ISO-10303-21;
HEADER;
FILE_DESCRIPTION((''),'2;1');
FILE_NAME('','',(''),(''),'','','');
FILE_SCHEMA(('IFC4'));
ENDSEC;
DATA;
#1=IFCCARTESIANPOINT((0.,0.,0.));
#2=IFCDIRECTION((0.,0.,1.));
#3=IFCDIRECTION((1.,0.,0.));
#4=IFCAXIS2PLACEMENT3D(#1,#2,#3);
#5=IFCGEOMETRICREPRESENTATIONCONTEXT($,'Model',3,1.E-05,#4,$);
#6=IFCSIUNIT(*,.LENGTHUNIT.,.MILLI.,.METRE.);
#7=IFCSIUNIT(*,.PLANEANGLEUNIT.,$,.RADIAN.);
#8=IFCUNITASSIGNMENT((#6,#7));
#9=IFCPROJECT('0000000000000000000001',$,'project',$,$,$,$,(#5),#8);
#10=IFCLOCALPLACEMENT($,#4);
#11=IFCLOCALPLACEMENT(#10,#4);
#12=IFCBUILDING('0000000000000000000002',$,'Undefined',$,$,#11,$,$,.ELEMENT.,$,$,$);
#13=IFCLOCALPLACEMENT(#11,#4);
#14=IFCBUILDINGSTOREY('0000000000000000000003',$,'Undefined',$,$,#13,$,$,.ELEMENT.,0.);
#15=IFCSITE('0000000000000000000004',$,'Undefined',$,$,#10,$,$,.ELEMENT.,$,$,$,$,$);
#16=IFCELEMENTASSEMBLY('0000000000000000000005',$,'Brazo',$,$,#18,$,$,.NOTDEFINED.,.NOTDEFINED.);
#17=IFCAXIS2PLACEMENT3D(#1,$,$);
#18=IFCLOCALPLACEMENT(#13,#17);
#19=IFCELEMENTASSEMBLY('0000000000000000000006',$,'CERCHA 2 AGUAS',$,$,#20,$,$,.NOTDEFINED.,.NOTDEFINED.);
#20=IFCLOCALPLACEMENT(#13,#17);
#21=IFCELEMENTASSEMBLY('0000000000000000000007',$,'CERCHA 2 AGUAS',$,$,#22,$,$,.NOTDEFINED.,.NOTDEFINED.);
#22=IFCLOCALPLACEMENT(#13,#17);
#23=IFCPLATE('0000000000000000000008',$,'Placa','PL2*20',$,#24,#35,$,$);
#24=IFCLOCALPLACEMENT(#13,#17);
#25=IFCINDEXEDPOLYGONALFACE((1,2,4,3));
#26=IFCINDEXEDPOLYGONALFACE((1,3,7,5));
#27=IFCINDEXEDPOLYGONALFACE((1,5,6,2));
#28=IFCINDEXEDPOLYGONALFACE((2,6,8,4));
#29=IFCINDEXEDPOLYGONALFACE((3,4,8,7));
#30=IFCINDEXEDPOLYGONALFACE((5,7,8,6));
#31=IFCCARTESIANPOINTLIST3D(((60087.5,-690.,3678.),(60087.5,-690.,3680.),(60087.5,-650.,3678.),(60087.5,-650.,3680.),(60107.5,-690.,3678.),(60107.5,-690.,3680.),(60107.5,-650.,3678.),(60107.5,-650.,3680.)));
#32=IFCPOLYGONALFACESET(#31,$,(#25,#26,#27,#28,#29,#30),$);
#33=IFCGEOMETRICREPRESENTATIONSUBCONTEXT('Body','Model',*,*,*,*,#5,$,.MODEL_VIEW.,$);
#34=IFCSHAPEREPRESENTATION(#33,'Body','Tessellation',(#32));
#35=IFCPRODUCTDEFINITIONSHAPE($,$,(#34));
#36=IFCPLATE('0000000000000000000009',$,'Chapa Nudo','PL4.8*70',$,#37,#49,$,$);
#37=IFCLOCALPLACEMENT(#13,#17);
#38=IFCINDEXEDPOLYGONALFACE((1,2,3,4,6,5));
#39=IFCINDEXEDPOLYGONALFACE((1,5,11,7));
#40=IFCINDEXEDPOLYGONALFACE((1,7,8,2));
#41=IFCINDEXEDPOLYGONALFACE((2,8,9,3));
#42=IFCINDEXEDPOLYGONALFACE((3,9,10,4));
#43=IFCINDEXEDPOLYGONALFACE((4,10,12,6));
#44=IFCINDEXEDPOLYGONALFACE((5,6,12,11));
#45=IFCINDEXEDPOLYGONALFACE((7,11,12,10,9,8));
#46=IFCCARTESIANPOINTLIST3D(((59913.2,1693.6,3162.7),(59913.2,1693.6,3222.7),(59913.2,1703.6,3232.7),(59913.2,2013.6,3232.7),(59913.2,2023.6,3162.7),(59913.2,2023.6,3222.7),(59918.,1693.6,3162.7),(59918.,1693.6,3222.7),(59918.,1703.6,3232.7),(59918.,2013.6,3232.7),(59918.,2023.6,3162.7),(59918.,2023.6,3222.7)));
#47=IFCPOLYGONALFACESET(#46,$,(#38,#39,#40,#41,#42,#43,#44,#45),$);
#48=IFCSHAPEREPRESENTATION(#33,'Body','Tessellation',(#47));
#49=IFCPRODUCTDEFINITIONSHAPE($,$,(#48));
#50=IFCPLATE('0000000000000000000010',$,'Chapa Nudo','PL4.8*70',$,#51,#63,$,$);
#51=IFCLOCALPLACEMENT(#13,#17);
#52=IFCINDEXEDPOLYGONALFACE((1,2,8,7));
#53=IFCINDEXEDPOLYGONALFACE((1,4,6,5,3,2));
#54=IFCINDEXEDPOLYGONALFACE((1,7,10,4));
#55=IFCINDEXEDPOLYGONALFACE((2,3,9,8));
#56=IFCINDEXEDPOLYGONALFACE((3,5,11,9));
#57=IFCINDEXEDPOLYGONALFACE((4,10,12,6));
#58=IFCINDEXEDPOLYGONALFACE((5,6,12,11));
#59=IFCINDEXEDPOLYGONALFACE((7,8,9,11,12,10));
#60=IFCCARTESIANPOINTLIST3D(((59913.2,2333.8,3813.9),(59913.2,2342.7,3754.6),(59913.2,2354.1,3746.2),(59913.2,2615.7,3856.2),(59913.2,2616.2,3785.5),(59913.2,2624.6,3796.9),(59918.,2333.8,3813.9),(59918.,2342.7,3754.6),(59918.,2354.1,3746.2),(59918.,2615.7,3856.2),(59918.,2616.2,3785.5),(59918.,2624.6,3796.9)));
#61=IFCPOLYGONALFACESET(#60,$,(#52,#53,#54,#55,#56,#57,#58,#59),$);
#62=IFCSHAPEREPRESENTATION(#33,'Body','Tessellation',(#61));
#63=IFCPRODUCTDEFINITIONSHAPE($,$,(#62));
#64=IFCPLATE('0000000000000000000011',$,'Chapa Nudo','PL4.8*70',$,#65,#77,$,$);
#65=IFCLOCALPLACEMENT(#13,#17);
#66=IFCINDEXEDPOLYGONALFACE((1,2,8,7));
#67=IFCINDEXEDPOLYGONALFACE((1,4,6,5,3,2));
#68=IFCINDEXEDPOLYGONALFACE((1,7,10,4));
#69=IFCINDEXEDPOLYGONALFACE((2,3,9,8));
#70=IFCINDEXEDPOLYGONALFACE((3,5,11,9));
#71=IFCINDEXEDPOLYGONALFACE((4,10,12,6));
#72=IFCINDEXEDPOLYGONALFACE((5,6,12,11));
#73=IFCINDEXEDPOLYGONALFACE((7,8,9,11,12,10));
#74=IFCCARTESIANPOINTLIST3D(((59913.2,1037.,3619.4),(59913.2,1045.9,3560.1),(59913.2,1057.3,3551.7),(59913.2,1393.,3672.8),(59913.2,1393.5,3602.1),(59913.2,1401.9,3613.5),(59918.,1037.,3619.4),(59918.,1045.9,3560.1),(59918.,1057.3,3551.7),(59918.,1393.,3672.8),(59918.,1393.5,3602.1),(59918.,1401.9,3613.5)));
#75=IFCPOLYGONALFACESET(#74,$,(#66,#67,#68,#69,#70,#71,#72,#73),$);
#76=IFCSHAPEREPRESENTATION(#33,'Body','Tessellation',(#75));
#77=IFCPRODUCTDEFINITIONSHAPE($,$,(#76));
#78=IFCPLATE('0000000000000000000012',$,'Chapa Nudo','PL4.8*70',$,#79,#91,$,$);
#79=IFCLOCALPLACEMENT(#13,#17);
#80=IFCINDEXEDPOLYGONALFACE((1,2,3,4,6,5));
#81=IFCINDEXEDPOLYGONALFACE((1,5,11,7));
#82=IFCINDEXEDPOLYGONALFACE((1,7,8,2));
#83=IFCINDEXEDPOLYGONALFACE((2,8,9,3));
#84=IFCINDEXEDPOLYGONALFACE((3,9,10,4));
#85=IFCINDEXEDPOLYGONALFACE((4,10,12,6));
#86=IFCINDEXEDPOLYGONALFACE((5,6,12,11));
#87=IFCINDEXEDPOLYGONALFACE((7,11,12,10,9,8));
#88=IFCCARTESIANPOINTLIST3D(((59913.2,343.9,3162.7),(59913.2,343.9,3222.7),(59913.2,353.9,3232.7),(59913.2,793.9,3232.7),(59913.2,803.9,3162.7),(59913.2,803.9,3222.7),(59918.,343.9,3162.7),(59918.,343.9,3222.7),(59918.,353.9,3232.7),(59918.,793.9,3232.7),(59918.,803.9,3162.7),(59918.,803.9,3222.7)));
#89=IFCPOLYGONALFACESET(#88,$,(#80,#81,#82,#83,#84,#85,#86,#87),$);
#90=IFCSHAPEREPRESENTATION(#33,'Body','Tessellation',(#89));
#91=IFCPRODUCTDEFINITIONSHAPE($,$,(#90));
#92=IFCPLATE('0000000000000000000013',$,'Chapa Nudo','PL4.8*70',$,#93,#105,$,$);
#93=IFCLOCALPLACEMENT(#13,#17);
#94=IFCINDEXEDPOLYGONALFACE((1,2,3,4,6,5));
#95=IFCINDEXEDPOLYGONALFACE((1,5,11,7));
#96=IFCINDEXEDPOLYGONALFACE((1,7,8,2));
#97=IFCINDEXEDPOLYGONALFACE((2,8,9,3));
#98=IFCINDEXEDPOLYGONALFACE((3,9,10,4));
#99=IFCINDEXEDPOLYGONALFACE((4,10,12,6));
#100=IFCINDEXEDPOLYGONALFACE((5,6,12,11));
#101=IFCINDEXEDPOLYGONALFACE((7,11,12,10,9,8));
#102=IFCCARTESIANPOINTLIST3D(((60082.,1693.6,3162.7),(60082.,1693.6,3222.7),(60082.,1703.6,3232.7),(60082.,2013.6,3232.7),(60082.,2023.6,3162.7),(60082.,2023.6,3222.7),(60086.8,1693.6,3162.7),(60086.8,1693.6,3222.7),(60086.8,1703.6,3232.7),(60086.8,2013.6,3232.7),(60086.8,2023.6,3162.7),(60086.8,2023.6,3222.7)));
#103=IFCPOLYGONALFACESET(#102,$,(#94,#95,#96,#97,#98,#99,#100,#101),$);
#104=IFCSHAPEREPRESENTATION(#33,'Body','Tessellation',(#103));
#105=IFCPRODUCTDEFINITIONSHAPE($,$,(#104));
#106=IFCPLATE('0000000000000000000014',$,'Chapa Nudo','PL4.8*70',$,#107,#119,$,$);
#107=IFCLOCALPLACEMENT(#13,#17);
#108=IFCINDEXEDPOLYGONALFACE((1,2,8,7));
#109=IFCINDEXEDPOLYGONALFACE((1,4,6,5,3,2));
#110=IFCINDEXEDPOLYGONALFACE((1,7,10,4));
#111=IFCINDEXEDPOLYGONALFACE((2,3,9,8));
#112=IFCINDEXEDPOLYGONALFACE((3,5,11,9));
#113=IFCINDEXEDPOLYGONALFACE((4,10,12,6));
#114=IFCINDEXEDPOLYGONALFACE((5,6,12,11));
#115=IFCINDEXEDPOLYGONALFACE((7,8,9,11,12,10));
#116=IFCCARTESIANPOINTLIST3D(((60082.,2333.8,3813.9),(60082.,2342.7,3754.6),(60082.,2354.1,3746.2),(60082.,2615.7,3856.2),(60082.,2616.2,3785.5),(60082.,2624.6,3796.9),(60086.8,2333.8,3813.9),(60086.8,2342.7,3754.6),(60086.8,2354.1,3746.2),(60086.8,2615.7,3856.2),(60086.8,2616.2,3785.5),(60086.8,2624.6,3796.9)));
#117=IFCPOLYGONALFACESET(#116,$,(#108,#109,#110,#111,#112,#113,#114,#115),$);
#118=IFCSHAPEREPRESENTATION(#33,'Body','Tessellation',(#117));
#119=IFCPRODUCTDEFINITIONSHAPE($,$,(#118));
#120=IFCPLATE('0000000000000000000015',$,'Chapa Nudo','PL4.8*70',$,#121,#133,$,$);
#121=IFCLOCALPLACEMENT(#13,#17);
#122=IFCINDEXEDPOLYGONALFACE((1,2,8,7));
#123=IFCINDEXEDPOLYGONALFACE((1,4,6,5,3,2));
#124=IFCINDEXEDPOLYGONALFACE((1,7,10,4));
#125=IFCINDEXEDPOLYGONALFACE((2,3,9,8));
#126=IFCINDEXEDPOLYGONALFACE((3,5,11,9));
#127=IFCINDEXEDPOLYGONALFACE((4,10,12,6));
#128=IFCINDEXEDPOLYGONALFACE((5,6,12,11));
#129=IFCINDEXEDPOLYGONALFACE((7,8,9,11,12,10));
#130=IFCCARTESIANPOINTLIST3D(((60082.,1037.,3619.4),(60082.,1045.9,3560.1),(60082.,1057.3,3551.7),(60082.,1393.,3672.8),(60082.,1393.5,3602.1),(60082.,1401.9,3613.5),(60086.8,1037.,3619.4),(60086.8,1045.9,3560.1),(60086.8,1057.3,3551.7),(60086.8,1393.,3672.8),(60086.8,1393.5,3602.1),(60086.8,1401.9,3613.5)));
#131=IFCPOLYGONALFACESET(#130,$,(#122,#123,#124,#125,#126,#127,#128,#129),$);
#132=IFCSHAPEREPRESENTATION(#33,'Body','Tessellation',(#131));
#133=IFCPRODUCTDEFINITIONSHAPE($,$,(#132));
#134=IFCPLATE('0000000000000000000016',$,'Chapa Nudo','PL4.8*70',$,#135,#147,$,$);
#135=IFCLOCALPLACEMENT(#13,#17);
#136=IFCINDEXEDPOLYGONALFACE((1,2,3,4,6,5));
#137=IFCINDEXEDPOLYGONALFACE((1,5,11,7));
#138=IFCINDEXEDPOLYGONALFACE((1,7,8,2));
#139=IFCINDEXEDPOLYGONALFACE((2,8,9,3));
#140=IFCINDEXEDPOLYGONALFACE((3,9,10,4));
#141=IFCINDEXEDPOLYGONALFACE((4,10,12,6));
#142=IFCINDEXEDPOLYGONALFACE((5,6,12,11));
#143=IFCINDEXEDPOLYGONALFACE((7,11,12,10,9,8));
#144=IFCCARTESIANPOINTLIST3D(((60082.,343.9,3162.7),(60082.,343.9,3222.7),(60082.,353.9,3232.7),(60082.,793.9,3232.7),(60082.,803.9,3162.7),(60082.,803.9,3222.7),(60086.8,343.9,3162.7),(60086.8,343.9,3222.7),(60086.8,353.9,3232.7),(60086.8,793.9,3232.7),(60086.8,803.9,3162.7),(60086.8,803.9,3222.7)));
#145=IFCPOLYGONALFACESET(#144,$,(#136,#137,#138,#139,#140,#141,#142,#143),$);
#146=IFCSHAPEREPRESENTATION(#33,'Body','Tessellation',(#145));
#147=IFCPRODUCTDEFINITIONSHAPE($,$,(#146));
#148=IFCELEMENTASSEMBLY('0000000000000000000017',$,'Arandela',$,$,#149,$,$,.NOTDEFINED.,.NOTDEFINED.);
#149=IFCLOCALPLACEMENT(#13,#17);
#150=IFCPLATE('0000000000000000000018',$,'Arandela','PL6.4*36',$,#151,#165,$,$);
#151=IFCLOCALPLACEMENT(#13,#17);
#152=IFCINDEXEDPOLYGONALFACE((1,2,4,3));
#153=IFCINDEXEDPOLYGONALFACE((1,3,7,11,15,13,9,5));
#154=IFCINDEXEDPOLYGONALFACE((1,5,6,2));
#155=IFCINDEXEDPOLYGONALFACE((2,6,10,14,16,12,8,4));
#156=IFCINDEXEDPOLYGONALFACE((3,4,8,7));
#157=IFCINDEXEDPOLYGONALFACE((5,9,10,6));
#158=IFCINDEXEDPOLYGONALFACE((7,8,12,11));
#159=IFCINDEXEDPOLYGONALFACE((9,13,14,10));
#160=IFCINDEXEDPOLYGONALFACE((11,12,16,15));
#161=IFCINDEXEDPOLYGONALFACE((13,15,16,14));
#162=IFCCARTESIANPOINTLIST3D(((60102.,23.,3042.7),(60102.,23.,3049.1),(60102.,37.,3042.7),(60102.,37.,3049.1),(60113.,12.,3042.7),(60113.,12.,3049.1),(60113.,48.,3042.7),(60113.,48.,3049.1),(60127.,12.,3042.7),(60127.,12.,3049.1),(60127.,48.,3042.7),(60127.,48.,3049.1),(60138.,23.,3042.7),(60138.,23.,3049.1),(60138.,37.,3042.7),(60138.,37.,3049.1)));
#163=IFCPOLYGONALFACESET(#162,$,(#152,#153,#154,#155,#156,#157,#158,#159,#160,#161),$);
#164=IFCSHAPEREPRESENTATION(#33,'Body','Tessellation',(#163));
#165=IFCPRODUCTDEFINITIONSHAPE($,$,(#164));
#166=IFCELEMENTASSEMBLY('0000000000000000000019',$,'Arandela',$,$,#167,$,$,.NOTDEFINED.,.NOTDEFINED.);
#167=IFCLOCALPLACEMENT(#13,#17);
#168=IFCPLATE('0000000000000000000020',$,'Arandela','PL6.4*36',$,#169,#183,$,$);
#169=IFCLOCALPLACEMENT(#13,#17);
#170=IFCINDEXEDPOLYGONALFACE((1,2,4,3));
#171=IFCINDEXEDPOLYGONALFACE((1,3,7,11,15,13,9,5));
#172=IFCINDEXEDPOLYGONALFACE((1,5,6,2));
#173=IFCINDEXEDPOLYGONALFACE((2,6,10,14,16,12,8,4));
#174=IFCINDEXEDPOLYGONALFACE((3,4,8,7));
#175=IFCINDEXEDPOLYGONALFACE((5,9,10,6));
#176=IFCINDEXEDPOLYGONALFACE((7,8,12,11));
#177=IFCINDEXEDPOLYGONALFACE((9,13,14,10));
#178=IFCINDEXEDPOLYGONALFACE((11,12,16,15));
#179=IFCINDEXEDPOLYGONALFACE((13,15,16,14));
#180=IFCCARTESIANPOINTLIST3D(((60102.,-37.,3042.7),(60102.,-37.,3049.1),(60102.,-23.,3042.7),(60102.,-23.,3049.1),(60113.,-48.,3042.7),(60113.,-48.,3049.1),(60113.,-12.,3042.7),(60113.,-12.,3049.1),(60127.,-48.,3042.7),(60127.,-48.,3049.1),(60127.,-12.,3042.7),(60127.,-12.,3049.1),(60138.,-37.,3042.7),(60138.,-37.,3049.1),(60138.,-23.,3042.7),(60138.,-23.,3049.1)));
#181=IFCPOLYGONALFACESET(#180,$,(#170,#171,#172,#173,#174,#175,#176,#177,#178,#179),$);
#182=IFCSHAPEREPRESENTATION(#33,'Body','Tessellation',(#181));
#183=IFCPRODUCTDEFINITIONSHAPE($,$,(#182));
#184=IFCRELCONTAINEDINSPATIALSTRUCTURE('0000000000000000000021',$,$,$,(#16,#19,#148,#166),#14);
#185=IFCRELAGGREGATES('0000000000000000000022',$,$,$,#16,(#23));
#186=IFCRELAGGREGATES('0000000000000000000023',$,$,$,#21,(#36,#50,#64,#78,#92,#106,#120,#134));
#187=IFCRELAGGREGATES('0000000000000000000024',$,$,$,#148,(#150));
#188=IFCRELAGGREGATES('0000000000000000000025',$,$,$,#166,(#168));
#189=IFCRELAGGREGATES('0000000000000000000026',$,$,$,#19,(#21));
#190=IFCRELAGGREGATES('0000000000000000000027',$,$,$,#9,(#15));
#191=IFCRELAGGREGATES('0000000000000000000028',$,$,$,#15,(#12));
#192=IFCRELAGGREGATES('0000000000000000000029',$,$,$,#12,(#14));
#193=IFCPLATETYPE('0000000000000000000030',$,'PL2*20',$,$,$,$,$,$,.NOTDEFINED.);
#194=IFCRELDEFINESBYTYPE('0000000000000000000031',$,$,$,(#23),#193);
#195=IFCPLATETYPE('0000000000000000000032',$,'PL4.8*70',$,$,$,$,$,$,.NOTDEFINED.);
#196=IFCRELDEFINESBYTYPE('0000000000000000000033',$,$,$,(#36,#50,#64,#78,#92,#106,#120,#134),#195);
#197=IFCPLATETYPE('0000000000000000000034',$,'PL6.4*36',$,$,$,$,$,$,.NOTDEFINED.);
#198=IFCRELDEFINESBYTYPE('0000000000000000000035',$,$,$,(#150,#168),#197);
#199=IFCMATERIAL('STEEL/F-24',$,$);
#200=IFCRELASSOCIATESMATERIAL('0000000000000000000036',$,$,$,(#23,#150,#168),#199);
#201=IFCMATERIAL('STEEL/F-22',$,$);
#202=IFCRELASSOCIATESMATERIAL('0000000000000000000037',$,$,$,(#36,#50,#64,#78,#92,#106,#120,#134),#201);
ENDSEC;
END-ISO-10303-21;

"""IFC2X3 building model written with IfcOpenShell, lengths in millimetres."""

from ifc_helpers import new_model, si_unit, frame, origin_with_axes, place, context, subcontext, project, spatial, polyline, outline, extrude, material, type_object, element, aggregate, save


model = new_model("IFC2X3")

# Units and contexts
model_context = context("Model", 3, precision=1e-05, world=origin_with_axes())
body_context = subcontext(model_context, "Body", "Model", "MODEL_VIEW")
ifc_project = project(units=[si_unit("LENGTHUNIT", "METRE", prefix="MILLI"), si_unit("PLANEANGLEUNIT", "RADIAN")], contexts=[model_context])

# Site, building, storey
site_placement = place(None, origin_with_axes())
site = spatial("IfcSite", under=ifc_project, at=site_placement, Name="Undefined", CompositionType="ELEMENT")
building_placement = place(site_placement, origin_with_axes())
building = spatial("IfcBuilding", under=site, at=building_placement, Name="Undefined", CompositionType="ELEMENT")
storey_placement = place(building_placement, origin_with_axes())
storey = spatial("IfcBuildingStorey", under=building, at=storey_placement, Name="Undefined", CompositionType="ELEMENT", Elevation=0.0)

# Element assembly
assembly_1_placement = place(storey_placement, origin_with_axes())
assembly_1 = element("IfcElementAssembly", 1, at=assembly_1_placement, inside=storey, Name="Brazo", AssemblyPlace="NOTDEFINED", PredefinedType="NOTDEFINED")

# Element assemblies
assembly_2_placement = place(storey_placement, origin_with_axes())
assembly_2 = element("IfcElementAssembly", 2, at=assembly_2_placement, inside=storey, Name="CERCHA 2 AGUAS", AssemblyPlace="NOTDEFINED", PredefinedType="NOTDEFINED")
assembly_3_placement = place(assembly_2_placement, origin_with_axes())
assembly_3 = element("IfcElementAssembly", 3, at=assembly_3_placement, Name="CERCHA 2 AGUAS", AssemblyPlace="NOTDEFINED", PredefinedType="NOTDEFINED")
ifc_material_1 = material(Name="STEEL/F-22")

# Shared definitions
ifc_material_2 = material(Name="STEEL/F-24")

# Plates
plate_type_1 = type_object("IfcPlateType", Name="PL2*20", PredefinedType="NOTDEFINED")
plate_1_placement = place(assembly_1_placement, frame((60087.5, -690.0, 3679.0), z_axis=(0.0, 0.000121, -1.0), x_axis=(-0.000071, 1.0, 0.000121)))
plate_1 = element("IfcPlate", 4, at=plate_1_placement, type_object=plate_type_1, material=ifc_material_2, Name="Placa", Description="PL2*20", context=body_context, shape_type="SweptSolid", body=[
    extrude(outline(polyline([(0.0, 0.0), (40.0, 0.0), (40.0, 20.0), (0.0, 20.0), (0.0, 0.0)])), frame((0.0, 0.0, -1.0), z_axis=(0.0, 0.0, 1.0), x_axis=(1.0, 0.0, 0.0)), (0.0, 0.0, 1.0), 2.0),
])
aggregate(assembly_1, [plate_1])
plate_type_2 = type_object("IfcPlateType", Name="PL4.8*70", PredefinedType="NOTDEFINED")
plate_2_placement = place(assembly_3_placement, frame((59915.6, 1693.6, 3232.7), z_axis=(1.0, 0.0, 0.0), x_axis=(0.0, 0.0, -1.0)))
plate_2 = element("IfcPlate", 5, at=plate_2_placement, type_object=plate_type_2, material=ifc_material_1, Name="Chapa Nudo", Description="PL4.8*70", context=body_context, shape_type="SweptSolid", body=[
    extrude(outline(polyline([(0.0, 10.0), (10.0, 0.0), (70.0, 0.0), (70.0, 330.0), (10.0, 330.0), (0.0, 320.0), (0.0, 10.0)])), frame((0.0, 0.0, -2.4), z_axis=(0.0, 0.0, 1.0), x_axis=(1.0, 0.0, 0.0)), (0.0, 0.0, 1.0), 4.8),
])
plate_3_placement = place(assembly_3_placement, frame((59915.6, 2333.8, 3813.9), z_axis=(1.0, 0.0, 0.0), x_axis=(0.0, 0.14834, -0.988936)))
plate_3 = element("IfcPlate", 6, at=plate_3_placement, type_object=plate_type_2, material=ifc_material_1, Name="Chapa Nudo", Description="PL4.8*70", context=body_context, shape_type="SweptSolid", body=[
    extrude(outline(polyline([(0.0, 0.0), (60.0, 0.0), (70.0, 10.0), (70.0, 275.0), (60.0, 285.0), (0.0, 285.0), (0.0, 0.0)])), frame((0.0, 0.0, -2.4), z_axis=(0.0, 0.0, 1.0), x_axis=(1.0, 0.0, 0.0)), (0.0, 0.0, 1.0), 4.8),
])
plate_4_placement = place(assembly_3_placement, frame((59915.6, 1037.0, 3619.4), z_axis=(1.0, 0.0, 0.0), x_axis=(0.0, 0.148337, -0.988937)))
plate_4 = element("IfcPlate", 7, at=plate_4_placement, type_object=plate_type_2, material=ifc_material_1, Name="Chapa Nudo", Description="PL4.8*70", context=body_context, shape_type="SweptSolid", body=[
    extrude(outline(polyline([(0.0, 0.0), (60.0, 0.0), (70.0, 10.0), (70.0, 350.0), (60.0, 360.0), (0.0, 360.0), (0.0, 0.0)])), frame((0.0, 0.0, -2.4), z_axis=(0.0, 0.0, 1.0), x_axis=(1.0, 0.0, 0.0)), (0.0, 0.0, 1.0), 4.8),
])
plate_5_placement = place(assembly_3_placement, frame((59915.6, 343.9, 3232.7), z_axis=(1.0, 0.0, 0.0), x_axis=(0.0, 0.0, -1.0)))
plate_5 = element("IfcPlate", 8, at=plate_5_placement, type_object=plate_type_2, material=ifc_material_1, Name="Chapa Nudo", Description="PL4.8*70", context=body_context, shape_type="SweptSolid", body=[
    extrude(outline(polyline([(0.0, 10.0), (10.0, 0.0), (70.0, 0.0), (70.0, 460.0), (10.0, 460.0), (0.0, 450.0), (0.0, 10.0)])), frame((0.0, 0.0, -2.4), z_axis=(0.0, 0.0, 1.0), x_axis=(1.0, 0.0, 0.0)), (0.0, 0.0, 1.0), 4.8),
])
plate_6_placement = place(assembly_3_placement, frame((60084.4, 1693.6, 3232.7), z_axis=(1.0, 0.0, 0.0), x_axis=(0.0, 0.0, -1.0)))
plate_6 = element("IfcPlate", 9, at=plate_6_placement, type_object=plate_type_2, material=ifc_material_1, Name="Chapa Nudo", Description="PL4.8*70", context=body_context, shape_type="SweptSolid", body=[
    extrude(outline(polyline([(0.0, 10.0), (10.0, 0.0), (70.0, 0.0), (70.0, 330.0), (10.0, 330.0), (0.0, 320.0), (0.0, 10.0)])), frame((0.0, 0.0, -2.4), z_axis=(0.0, 0.0, 1.0), x_axis=(1.0, 0.0, 0.0)), (0.0, 0.0, 1.0), 4.8),
])
plate_7_placement = place(assembly_3_placement, frame((60084.4, 2333.8, 3813.9), z_axis=(1.0, 0.0, 0.0), x_axis=(0.0, 0.14834, -0.988936)))
plate_7 = element("IfcPlate", 10, at=plate_7_placement, type_object=plate_type_2, material=ifc_material_1, Name="Chapa Nudo", Description="PL4.8*70", context=body_context, shape_type="SweptSolid", body=[
    extrude(outline(polyline([(0.0, 0.0), (60.0, 0.0), (70.0, 10.0), (70.0, 275.0), (60.0, 285.0), (0.0, 285.0), (0.0, 0.0)])), frame((0.0, 0.0, -2.4), z_axis=(0.0, 0.0, 1.0), x_axis=(1.0, 0.0, 0.0)), (0.0, 0.0, 1.0), 4.8),
])
plate_8_placement = place(assembly_3_placement, frame((60084.4, 1037.0, 3619.4), z_axis=(1.0, 0.0, 0.0), x_axis=(0.0, 0.148337, -0.988937)))
plate_8 = element("IfcPlate", 11, at=plate_8_placement, type_object=plate_type_2, material=ifc_material_1, Name="Chapa Nudo", Description="PL4.8*70", context=body_context, shape_type="SweptSolid", body=[
    extrude(outline(polyline([(0.0, 0.0), (60.0, 0.0), (70.0, 10.0), (70.0, 350.0), (60.0, 360.0), (0.0, 360.0), (0.0, 0.0)])), frame((0.0, 0.0, -2.4), z_axis=(0.0, 0.0, 1.0), x_axis=(1.0, 0.0, 0.0)), (0.0, 0.0, 1.0), 4.8),
])
plate_9_placement = place(assembly_3_placement, frame((60084.4, 343.9, 3232.7), z_axis=(1.0, 0.0, 0.0), x_axis=(0.0, 0.0, -1.0)))
plate_9 = element("IfcPlate", 12, at=plate_9_placement, type_object=plate_type_2, material=ifc_material_1, Name="Chapa Nudo", Description="PL4.8*70", context=body_context, shape_type="SweptSolid", body=[
    extrude(outline(polyline([(0.0, 10.0), (10.0, 0.0), (70.0, 0.0), (70.0, 460.0), (10.0, 460.0), (0.0, 450.0), (0.0, 10.0)])), frame((0.0, 0.0, -2.4), z_axis=(0.0, 0.0, 1.0), x_axis=(1.0, 0.0, 0.0)), (0.0, 0.0, 1.0), 4.8),
])

# Element assemblies, plates
assembly_4_placement = place(storey_placement, origin_with_axes())
assembly_4 = element("IfcElementAssembly", 13, at=assembly_4_placement, inside=storey, Name="Arandela", AssemblyPlace="NOTDEFINED", PredefinedType="NOTDEFINED")
plate_type_3 = type_object("IfcPlateType", Name="PL6.4*36", PredefinedType="NOTDEFINED")
plate_10_placement = place(assembly_4_placement, frame((60102.0, 48.0, 3045.9), z_axis=(0.0, 0.0, 1.0), x_axis=(0.0, -1.0, 0.0)))
plate_10 = element("IfcPlate", 14, at=plate_10_placement, type_object=plate_type_3, material=ifc_material_2, Name="Arandela", Description="PL6.4*36", context=body_context, shape_type="SweptSolid", body=[
    extrude(outline(polyline([(0.0, 11.0), (11.0, 0.0), (25.0, 0.0), (36.0, 11.0), (36.0, 25.0), (25.0, 36.0), (11.0, 36.0), (0.0, 25.0), (0.0, 11.0)])), frame((0.0, 0.0, -3.2), z_axis=(0.0, 0.0, 1.0), x_axis=(1.0, 0.0, 0.0)), (0.0, 0.0, 1.0), 6.4),
])
assembly_5_placement = place(storey_placement, origin_with_axes())
assembly_5 = element("IfcElementAssembly", 15, at=assembly_5_placement, inside=storey, Name="Arandela", AssemblyPlace="NOTDEFINED", PredefinedType="NOTDEFINED")
plate_11_placement = place(assembly_5_placement, frame((60102.0, -12.0, 3045.9), z_axis=(0.0, 0.0, 1.0), x_axis=(0.0, -1.0, 0.0)))
plate_11 = element("IfcPlate", 16, at=plate_11_placement, type_object=plate_type_3, material=ifc_material_2, Name="Arandela", Description="PL6.4*36", context=body_context, shape_type="SweptSolid", body=[
    extrude(outline(polyline([(0.0, 11.0), (11.0, 0.0), (25.0, 0.0), (36.0, 11.0), (36.0, 25.0), (25.0, 36.0), (11.0, 36.0), (0.0, 25.0), (0.0, 11.0)])), frame((0.0, 0.0, -3.2), z_axis=(0.0, 0.0, 1.0), x_axis=(1.0, 0.0, 0.0)), (0.0, 0.0, 1.0), 6.4),
])

aggregate(assembly_3, [plate_2, plate_3, plate_4, plate_5, plate_6, plate_7, plate_8, plate_9])
aggregate(assembly_4, [plate_10])
aggregate(assembly_5, [plate_11])

aggregate(assembly_2, [assembly_3])

save(model, "model.ifc")
